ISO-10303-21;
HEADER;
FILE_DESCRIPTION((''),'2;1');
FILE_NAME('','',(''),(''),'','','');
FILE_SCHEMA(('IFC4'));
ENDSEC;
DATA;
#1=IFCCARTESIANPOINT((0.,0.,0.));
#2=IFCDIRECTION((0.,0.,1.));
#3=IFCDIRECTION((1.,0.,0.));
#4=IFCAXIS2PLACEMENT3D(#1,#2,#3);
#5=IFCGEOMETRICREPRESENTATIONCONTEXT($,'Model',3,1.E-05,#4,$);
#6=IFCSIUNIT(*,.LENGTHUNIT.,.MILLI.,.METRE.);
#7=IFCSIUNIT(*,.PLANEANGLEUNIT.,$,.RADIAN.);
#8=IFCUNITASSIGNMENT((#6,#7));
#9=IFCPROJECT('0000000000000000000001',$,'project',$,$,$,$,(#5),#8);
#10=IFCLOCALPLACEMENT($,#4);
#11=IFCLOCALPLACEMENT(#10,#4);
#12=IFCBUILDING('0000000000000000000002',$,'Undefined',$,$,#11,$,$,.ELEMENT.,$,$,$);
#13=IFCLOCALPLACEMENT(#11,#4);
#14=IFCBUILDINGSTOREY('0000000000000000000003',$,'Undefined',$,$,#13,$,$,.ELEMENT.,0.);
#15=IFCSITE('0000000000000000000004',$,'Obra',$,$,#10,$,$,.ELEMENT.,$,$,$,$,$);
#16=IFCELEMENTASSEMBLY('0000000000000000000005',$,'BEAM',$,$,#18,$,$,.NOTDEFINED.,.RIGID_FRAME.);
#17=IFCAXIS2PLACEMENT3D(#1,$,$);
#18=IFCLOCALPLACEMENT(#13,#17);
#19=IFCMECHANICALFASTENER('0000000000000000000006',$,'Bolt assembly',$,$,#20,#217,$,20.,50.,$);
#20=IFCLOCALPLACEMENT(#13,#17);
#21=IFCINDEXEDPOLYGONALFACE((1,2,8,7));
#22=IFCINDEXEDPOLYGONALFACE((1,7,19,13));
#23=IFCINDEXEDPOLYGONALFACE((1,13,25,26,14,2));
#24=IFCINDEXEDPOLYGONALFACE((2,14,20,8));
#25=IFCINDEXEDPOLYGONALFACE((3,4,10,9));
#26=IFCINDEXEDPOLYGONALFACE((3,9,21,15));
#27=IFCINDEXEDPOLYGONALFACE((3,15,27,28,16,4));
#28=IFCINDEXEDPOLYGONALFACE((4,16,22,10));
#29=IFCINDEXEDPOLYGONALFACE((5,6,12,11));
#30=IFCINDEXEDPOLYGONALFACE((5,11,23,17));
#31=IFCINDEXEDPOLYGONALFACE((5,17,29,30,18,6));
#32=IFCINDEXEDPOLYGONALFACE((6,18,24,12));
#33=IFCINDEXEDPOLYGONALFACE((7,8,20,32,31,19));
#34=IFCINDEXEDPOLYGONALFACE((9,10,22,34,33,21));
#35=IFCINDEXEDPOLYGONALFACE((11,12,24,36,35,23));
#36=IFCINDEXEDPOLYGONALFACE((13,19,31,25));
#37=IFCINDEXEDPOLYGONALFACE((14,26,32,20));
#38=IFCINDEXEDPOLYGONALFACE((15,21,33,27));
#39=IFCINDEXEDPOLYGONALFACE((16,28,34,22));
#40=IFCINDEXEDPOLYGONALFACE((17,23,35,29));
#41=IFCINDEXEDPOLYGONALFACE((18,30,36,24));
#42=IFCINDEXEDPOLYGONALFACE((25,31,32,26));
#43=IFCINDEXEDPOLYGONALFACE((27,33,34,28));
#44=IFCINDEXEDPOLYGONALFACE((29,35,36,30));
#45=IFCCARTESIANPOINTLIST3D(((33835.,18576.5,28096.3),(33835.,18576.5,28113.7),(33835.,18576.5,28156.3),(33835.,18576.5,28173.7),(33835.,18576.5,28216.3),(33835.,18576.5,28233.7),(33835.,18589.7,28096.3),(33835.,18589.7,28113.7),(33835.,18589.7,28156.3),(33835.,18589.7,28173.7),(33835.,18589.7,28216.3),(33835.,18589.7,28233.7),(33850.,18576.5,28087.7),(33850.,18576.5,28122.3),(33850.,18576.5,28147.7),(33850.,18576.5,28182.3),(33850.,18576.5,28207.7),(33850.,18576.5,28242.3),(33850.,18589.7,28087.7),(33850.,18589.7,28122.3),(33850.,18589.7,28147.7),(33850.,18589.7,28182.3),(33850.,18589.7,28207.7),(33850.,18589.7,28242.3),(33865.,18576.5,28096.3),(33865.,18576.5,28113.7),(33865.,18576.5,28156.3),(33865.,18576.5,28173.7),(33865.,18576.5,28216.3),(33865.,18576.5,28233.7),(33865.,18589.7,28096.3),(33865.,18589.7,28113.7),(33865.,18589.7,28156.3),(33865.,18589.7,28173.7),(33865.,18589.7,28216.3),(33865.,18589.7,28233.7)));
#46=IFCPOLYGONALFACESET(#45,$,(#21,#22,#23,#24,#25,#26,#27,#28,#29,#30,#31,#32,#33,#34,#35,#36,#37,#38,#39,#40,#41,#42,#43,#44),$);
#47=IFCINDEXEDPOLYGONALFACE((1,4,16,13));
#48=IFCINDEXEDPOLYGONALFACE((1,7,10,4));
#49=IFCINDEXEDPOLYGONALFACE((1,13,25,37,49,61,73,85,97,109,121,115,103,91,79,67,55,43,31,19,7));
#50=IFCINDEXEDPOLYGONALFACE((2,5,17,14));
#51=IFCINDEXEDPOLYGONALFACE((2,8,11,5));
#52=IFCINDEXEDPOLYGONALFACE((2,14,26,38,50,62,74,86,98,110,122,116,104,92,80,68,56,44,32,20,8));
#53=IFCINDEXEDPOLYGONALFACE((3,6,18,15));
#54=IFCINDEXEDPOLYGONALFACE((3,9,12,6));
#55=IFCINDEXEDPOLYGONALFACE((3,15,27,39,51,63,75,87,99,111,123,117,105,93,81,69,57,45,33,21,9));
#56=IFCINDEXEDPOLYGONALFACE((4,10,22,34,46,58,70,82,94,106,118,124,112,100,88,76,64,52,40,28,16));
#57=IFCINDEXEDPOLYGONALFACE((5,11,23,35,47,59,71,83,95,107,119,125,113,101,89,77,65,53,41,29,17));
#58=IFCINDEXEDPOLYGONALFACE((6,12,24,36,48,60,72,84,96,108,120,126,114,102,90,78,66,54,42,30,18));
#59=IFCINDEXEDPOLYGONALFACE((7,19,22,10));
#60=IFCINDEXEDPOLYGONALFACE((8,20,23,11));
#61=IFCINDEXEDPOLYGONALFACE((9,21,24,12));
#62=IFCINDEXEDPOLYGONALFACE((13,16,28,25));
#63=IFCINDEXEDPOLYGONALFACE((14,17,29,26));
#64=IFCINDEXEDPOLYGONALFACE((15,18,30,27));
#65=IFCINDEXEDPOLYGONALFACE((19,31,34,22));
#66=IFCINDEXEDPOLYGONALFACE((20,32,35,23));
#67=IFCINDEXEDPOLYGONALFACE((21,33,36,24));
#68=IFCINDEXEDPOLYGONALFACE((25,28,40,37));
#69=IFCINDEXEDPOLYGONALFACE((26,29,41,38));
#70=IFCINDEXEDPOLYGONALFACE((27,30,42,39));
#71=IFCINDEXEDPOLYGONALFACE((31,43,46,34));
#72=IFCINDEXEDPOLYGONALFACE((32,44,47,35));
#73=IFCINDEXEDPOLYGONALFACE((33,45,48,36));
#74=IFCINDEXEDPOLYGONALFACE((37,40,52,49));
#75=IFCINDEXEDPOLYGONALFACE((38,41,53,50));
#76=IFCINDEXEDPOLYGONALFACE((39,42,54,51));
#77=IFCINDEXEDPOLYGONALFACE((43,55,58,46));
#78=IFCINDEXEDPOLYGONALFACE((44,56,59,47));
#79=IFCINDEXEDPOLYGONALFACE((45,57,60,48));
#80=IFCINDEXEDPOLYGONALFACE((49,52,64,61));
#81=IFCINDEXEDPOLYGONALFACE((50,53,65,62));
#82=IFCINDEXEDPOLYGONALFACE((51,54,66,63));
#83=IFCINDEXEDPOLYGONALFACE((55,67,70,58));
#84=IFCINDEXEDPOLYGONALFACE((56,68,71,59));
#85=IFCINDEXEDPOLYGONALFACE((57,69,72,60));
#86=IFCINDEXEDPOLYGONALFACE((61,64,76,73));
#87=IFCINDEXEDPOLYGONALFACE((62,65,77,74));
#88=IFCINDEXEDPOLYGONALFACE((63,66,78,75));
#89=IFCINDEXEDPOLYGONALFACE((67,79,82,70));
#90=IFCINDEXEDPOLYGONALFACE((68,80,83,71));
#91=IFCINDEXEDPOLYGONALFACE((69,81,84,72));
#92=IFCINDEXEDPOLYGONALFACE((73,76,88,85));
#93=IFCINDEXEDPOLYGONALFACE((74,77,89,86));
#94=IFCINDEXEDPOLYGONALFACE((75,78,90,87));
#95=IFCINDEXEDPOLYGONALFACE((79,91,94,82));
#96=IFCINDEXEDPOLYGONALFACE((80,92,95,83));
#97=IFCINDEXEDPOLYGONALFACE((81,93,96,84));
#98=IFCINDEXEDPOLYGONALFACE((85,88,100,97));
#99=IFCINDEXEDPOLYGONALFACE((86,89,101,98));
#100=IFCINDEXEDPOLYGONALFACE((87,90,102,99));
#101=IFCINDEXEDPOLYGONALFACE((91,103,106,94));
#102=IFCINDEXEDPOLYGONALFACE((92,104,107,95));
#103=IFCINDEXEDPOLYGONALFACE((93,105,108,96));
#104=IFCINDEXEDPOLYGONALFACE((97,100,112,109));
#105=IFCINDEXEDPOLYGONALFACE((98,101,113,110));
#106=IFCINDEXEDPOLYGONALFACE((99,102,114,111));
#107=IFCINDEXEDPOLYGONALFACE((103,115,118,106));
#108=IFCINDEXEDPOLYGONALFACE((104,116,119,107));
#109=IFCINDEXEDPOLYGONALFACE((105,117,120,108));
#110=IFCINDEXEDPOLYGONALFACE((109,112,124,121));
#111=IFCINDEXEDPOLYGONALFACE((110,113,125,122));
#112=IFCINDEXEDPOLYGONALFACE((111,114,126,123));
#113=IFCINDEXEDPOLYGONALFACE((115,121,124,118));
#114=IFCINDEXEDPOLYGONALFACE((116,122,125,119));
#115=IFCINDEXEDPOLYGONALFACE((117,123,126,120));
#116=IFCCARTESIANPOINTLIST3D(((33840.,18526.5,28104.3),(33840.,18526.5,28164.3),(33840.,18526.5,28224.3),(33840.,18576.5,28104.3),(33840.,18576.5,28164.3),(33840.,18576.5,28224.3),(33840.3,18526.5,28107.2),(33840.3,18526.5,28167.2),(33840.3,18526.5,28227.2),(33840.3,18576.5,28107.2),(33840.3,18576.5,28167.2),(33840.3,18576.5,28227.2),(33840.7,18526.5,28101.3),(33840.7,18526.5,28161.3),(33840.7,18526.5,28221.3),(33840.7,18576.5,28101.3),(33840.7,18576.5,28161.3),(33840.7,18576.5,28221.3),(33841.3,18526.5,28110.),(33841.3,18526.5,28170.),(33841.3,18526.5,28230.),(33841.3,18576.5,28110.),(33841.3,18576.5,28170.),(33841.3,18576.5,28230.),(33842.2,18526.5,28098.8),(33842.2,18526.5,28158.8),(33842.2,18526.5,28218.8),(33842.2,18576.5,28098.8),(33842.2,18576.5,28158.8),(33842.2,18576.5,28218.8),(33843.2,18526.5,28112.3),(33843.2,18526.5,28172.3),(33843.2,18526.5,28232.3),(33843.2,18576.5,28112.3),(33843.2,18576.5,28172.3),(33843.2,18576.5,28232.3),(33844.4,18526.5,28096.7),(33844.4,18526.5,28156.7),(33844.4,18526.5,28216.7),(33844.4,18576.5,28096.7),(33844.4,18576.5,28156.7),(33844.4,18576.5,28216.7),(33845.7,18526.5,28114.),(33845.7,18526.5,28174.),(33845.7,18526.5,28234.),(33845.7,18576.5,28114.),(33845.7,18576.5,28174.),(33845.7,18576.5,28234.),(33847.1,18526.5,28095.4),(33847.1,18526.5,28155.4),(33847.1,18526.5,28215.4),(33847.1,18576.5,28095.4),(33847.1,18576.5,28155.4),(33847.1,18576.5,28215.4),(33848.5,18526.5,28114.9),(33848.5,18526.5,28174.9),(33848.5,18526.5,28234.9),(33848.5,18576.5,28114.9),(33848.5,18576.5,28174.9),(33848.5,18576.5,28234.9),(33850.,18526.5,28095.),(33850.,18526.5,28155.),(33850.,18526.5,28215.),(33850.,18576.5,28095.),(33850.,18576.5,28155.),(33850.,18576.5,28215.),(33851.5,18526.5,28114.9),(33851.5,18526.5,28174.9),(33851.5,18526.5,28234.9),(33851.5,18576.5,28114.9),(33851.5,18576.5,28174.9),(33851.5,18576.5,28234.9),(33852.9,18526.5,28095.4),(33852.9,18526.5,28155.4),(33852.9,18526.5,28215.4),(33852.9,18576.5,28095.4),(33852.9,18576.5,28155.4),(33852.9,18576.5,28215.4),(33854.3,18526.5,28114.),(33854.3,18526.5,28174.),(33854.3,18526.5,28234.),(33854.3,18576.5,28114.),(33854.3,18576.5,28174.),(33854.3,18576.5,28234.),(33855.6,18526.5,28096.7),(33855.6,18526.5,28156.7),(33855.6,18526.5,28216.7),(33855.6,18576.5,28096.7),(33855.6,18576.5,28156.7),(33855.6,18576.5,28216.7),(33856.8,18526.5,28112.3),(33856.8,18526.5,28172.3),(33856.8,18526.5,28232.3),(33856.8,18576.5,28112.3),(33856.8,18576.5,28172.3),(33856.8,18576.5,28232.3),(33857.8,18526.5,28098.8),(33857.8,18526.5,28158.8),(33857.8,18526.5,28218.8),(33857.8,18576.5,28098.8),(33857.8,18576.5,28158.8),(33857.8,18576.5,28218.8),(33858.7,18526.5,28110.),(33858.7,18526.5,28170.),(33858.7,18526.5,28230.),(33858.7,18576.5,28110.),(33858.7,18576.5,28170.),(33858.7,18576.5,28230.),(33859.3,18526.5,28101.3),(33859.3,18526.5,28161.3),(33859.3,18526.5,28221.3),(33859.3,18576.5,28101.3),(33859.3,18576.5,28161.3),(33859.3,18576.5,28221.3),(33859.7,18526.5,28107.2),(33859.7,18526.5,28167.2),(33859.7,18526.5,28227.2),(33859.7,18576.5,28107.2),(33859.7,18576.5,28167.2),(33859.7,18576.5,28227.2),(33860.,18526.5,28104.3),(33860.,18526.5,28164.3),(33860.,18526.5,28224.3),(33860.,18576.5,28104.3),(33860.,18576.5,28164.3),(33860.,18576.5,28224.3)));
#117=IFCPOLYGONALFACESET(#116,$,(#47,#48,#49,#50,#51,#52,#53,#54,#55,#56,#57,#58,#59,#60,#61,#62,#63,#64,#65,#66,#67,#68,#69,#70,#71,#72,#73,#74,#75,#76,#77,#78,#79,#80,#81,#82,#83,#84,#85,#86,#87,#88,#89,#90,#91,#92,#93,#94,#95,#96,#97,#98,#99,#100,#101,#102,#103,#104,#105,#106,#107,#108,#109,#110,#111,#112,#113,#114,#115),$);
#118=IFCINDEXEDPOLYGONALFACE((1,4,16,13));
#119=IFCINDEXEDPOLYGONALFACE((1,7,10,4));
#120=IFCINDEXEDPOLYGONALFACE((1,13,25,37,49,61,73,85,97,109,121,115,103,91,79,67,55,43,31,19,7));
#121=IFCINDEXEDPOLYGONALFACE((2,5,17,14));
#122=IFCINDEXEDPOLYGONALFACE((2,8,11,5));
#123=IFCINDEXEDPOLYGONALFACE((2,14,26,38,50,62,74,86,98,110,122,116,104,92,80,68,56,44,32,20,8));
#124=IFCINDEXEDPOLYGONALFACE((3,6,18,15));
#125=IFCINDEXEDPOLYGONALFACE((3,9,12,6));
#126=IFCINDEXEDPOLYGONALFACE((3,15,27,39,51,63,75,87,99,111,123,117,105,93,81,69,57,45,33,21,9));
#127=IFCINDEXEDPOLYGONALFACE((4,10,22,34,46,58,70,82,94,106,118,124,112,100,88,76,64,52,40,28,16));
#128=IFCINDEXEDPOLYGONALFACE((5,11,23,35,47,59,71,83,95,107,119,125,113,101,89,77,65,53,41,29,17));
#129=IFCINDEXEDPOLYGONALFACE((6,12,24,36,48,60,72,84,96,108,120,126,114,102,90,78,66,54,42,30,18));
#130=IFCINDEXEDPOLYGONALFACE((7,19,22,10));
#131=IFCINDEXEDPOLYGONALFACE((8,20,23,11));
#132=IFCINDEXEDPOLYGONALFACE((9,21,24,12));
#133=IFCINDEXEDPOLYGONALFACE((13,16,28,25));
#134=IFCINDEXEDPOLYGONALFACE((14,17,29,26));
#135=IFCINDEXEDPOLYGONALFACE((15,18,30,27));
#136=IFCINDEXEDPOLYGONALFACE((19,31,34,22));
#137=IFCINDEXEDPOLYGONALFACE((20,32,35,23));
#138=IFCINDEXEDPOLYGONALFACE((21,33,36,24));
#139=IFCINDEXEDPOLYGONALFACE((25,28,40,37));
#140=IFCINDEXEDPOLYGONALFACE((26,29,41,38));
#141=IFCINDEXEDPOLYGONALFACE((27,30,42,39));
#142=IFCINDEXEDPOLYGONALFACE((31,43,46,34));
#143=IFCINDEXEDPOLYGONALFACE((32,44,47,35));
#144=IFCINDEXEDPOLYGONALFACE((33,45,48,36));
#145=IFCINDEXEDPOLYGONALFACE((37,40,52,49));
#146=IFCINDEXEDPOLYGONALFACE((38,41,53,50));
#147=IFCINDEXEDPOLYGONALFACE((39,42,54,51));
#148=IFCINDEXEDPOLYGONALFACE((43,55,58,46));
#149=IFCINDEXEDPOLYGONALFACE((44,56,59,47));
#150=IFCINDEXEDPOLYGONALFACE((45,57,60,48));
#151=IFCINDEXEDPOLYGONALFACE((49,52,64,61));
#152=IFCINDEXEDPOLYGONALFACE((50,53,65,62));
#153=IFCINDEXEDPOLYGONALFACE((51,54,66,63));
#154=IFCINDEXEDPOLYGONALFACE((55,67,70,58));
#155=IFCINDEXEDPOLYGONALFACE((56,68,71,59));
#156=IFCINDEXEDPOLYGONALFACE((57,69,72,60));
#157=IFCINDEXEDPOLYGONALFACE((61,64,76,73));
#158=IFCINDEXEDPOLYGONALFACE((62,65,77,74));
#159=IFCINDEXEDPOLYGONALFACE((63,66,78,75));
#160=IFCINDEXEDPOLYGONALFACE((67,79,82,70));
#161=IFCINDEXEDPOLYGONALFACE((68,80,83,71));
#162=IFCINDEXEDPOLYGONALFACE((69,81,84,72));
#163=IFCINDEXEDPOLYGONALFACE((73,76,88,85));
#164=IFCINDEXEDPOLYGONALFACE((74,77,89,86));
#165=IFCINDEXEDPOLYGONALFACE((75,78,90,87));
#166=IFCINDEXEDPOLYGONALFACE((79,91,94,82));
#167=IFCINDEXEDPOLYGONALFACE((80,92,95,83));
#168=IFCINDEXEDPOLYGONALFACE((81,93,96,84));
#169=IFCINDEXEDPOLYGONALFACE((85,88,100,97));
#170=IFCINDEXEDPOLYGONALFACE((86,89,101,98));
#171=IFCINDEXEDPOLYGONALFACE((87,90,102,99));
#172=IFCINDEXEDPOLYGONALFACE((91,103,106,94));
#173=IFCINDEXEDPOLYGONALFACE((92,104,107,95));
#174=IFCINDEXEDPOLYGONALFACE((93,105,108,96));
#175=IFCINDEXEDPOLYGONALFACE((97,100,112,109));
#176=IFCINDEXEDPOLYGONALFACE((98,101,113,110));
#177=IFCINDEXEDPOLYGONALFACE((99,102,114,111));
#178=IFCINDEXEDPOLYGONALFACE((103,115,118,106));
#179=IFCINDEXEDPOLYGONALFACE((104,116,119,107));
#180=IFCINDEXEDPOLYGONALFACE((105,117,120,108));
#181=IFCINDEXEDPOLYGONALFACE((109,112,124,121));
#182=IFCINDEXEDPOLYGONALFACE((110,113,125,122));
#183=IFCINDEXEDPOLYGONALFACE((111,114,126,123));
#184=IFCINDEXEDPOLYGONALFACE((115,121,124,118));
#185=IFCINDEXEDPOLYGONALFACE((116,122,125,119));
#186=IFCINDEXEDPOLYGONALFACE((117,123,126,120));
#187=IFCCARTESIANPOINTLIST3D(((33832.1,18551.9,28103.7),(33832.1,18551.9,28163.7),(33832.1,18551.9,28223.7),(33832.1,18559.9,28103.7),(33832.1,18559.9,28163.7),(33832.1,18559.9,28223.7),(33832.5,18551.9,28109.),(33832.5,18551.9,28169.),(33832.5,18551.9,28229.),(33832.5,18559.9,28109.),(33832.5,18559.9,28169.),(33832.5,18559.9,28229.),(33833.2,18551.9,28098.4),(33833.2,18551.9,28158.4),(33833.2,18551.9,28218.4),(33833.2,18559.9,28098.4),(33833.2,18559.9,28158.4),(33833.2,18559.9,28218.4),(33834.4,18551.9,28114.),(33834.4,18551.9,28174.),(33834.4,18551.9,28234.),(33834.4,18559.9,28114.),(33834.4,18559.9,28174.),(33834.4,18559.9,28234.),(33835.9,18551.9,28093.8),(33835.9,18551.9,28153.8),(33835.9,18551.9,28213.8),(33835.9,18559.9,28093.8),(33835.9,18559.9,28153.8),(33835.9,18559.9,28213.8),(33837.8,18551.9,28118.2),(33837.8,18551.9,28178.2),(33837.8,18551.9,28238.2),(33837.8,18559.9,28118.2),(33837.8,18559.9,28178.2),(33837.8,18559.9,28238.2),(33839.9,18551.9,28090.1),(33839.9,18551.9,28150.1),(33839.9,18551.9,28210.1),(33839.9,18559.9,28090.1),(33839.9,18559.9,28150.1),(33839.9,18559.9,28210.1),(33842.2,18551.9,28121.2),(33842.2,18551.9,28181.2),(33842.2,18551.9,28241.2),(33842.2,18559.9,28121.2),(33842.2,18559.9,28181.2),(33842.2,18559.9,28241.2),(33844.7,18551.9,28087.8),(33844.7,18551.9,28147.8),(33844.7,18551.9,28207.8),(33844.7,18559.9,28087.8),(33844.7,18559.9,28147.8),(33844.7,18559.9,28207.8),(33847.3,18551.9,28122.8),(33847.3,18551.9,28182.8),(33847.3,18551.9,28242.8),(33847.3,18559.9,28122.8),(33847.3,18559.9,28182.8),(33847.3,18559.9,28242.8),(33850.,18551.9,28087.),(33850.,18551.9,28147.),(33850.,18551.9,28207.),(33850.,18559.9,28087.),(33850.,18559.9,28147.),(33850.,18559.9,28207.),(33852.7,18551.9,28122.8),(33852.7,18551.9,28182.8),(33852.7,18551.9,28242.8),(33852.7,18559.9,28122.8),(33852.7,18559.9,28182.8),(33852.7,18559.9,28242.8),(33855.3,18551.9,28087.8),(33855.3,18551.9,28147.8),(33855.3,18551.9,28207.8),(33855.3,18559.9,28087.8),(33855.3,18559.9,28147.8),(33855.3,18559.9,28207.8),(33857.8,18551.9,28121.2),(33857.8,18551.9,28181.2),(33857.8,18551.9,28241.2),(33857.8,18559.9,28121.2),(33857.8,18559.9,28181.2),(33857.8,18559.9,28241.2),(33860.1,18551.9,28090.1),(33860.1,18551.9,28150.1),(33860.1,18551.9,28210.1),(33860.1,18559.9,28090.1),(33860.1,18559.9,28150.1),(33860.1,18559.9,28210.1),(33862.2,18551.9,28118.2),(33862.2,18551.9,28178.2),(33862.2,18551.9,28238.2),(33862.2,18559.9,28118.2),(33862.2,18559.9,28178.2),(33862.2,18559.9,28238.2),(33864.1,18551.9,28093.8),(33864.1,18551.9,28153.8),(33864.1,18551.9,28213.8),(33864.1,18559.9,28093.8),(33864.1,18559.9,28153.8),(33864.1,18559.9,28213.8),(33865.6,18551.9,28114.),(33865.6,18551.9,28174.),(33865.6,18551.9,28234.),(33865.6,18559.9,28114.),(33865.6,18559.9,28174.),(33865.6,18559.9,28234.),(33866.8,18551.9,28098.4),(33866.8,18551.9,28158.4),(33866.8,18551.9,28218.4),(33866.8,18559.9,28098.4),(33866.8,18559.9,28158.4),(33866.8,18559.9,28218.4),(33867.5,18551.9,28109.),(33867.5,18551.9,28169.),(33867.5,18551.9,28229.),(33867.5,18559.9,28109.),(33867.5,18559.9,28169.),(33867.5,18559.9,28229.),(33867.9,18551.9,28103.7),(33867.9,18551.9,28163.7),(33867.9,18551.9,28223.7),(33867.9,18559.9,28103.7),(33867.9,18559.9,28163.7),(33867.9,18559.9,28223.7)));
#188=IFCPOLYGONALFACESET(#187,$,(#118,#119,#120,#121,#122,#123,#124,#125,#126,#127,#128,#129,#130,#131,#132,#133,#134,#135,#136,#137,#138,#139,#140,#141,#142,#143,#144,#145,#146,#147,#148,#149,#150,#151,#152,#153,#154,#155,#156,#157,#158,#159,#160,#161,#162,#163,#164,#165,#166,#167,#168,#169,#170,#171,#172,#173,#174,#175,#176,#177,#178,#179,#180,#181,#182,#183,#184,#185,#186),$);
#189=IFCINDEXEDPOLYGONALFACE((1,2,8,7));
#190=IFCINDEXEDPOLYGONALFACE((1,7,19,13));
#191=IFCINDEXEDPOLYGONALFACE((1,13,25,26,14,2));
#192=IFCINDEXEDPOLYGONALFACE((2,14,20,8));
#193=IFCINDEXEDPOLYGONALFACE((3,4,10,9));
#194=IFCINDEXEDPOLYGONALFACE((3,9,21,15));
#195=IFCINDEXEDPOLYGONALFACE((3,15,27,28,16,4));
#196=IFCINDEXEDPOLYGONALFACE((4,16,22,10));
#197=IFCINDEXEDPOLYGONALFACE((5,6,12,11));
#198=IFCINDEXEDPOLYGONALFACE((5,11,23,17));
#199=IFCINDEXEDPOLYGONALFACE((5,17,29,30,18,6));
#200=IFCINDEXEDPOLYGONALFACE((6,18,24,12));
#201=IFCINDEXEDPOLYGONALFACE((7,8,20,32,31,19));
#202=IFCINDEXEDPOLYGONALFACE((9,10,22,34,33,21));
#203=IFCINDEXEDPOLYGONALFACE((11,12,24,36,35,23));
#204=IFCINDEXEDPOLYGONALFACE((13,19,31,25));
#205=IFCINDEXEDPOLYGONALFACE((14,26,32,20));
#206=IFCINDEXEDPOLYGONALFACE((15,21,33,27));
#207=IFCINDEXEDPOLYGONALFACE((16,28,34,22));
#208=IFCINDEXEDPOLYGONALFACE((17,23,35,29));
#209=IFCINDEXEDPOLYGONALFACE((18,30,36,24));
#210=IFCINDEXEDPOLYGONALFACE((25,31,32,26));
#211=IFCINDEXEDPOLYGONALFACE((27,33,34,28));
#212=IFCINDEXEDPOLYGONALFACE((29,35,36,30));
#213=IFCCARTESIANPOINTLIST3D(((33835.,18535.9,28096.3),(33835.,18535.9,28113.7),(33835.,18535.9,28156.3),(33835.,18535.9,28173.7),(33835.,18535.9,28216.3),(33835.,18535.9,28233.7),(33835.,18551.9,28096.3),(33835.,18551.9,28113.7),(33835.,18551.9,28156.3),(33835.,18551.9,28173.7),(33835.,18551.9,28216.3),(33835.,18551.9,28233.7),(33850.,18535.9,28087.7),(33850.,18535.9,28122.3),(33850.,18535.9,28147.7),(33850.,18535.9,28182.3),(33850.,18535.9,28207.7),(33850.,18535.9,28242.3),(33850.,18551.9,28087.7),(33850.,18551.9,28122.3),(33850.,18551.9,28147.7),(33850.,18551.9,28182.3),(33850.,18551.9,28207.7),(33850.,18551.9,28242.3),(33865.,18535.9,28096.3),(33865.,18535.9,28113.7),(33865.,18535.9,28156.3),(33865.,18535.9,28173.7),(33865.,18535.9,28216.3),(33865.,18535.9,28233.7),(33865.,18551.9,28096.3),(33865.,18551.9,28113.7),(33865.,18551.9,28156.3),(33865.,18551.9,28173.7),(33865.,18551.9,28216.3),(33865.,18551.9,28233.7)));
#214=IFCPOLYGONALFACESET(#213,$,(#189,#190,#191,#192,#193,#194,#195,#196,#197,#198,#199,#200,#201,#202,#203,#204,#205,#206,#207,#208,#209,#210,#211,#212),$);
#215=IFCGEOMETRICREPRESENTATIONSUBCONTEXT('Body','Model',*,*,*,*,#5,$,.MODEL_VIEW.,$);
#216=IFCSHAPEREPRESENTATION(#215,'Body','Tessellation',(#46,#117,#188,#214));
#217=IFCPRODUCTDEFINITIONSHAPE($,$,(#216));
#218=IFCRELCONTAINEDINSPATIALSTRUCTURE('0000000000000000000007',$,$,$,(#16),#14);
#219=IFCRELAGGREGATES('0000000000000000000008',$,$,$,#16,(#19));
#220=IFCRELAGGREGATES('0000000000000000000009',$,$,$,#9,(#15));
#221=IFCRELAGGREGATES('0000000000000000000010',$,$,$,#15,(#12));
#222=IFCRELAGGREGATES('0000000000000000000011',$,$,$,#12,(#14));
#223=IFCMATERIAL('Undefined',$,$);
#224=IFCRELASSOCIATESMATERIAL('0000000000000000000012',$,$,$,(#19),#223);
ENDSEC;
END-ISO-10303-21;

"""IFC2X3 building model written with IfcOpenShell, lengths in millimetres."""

from ifc_helpers import new_model, si_unit, frame, origin_with_axes, origin_2d_with_axis, place, context, subcontext, project, spatial, polyline, circle, outline, extrude, source, transform, mapped, material, element, aggregate, save


model = new_model("IFC2X3")

# Units and contexts
model_context = context("Model", 3, precision=1e-05, world=origin_with_axes())
body_context = subcontext(model_context, "Body", "Model", "MODEL_VIEW")
ifc_project = project(units=[si_unit("LENGTHUNIT", "METRE", prefix="MILLI"), si_unit("PLANEANGLEUNIT", "RADIAN")], contexts=[model_context])

# Site, building, storey
site_placement = place(None, origin_with_axes())
site = spatial("IfcSite", under=ifc_project, at=site_placement, Name="Obra", CompositionType="ELEMENT")
building_placement = place(site_placement, origin_with_axes())
building = spatial("IfcBuilding", under=site, at=building_placement, Name="Undefined", CompositionType="ELEMENT")
storey_placement = place(building_placement, origin_with_axes())
storey = spatial("IfcBuildingStorey", under=building, at=storey_placement, Name="Undefined", CompositionType="ELEMENT", Elevation=0.0)

# Element assembly
assembly_1_placement = place(storey_placement, origin_with_axes())
assembly_1 = element("IfcElementAssembly", 1, at=assembly_1_placement, inside=storey, Name="BEAM", AssemblyPlace="NOTDEFINED", PredefinedType="RIGID_FRAME")

# Shared definitions
ifc_material_1 = material(Name="Undefined")
shared_shape_1 = source(origin_with_axes(), body_context, "Body", "SweptSolid", [
    extrude(outline(polyline([(17.3, 0.0), (8.7, 15.0), (-8.7, 15.0), (-17.3, 0.0), (-8.7, -15.0), (8.7, -15.0), (17.3, 0.0)])), frame((0.0, -26.5, 0.0), z_axis=(0.0, 1.0, 0.0), x_axis=(1.0, 0.0, 0.0)), (0.0, 0.0, 1.0), 13.2),
    extrude(circle(Radius=10.0, at=origin_2d_with_axis()), frame((0.0, -13.3, 0.0), z_axis=(0.0, 1.0, 0.0), x_axis=(1.0, 0.0, 0.0)), (0.0, 0.0, 1.0), 50.0),
    extrude(circle(Radius=18.0, at=origin_2d_with_axis()), frame((0.0, 3.3, 0.0), z_axis=(0.0, 1.0, 0.0), x_axis=(1.0, 0.0, 0.0)), (0.0, 0.0, 1.0), 8.0),
    extrude(outline(polyline([(17.3, 0.0), (8.7, 15.0), (-8.7, 15.0), (-17.3, 0.0), (-8.7, -15.0), (8.7, -15.0), (17.3, 0.0)])), frame((0.0, 11.3, 0.0), z_axis=(0.0, 1.0, 0.0), x_axis=(1.0, 0.0, 0.0)), (0.0, 0.0, 1.0), 16.0),
])

# Mechanical fastener
mechanical_fastener_1_placement = place(assembly_1_placement, frame((33900.0, 18563.2, 28265.0), z_axis=(-1.0, 0.0, 0.0), x_axis=(0.0, 0.0, -1.0)))
mechanical_fastener_1 = element("IfcMechanicalFastener", 2, at=mechanical_fastener_1_placement, material=ifc_material_1, Name="Bolt assembly", NominalDiameter=20.0, NominalLength=50.0, context=body_context, shape_type="MappedRepresentation", body=[
    mapped(shared_shape_1, transform((40.0, 0.0, 50.0))),
    mapped(shared_shape_1, transform((100.0, 0.0, 50.0))),
    mapped(shared_shape_1, transform((160.0, 0.0, 50.0))),
])
aggregate(assembly_1, [mechanical_fastener_1])

save(model, "model.ifc")
